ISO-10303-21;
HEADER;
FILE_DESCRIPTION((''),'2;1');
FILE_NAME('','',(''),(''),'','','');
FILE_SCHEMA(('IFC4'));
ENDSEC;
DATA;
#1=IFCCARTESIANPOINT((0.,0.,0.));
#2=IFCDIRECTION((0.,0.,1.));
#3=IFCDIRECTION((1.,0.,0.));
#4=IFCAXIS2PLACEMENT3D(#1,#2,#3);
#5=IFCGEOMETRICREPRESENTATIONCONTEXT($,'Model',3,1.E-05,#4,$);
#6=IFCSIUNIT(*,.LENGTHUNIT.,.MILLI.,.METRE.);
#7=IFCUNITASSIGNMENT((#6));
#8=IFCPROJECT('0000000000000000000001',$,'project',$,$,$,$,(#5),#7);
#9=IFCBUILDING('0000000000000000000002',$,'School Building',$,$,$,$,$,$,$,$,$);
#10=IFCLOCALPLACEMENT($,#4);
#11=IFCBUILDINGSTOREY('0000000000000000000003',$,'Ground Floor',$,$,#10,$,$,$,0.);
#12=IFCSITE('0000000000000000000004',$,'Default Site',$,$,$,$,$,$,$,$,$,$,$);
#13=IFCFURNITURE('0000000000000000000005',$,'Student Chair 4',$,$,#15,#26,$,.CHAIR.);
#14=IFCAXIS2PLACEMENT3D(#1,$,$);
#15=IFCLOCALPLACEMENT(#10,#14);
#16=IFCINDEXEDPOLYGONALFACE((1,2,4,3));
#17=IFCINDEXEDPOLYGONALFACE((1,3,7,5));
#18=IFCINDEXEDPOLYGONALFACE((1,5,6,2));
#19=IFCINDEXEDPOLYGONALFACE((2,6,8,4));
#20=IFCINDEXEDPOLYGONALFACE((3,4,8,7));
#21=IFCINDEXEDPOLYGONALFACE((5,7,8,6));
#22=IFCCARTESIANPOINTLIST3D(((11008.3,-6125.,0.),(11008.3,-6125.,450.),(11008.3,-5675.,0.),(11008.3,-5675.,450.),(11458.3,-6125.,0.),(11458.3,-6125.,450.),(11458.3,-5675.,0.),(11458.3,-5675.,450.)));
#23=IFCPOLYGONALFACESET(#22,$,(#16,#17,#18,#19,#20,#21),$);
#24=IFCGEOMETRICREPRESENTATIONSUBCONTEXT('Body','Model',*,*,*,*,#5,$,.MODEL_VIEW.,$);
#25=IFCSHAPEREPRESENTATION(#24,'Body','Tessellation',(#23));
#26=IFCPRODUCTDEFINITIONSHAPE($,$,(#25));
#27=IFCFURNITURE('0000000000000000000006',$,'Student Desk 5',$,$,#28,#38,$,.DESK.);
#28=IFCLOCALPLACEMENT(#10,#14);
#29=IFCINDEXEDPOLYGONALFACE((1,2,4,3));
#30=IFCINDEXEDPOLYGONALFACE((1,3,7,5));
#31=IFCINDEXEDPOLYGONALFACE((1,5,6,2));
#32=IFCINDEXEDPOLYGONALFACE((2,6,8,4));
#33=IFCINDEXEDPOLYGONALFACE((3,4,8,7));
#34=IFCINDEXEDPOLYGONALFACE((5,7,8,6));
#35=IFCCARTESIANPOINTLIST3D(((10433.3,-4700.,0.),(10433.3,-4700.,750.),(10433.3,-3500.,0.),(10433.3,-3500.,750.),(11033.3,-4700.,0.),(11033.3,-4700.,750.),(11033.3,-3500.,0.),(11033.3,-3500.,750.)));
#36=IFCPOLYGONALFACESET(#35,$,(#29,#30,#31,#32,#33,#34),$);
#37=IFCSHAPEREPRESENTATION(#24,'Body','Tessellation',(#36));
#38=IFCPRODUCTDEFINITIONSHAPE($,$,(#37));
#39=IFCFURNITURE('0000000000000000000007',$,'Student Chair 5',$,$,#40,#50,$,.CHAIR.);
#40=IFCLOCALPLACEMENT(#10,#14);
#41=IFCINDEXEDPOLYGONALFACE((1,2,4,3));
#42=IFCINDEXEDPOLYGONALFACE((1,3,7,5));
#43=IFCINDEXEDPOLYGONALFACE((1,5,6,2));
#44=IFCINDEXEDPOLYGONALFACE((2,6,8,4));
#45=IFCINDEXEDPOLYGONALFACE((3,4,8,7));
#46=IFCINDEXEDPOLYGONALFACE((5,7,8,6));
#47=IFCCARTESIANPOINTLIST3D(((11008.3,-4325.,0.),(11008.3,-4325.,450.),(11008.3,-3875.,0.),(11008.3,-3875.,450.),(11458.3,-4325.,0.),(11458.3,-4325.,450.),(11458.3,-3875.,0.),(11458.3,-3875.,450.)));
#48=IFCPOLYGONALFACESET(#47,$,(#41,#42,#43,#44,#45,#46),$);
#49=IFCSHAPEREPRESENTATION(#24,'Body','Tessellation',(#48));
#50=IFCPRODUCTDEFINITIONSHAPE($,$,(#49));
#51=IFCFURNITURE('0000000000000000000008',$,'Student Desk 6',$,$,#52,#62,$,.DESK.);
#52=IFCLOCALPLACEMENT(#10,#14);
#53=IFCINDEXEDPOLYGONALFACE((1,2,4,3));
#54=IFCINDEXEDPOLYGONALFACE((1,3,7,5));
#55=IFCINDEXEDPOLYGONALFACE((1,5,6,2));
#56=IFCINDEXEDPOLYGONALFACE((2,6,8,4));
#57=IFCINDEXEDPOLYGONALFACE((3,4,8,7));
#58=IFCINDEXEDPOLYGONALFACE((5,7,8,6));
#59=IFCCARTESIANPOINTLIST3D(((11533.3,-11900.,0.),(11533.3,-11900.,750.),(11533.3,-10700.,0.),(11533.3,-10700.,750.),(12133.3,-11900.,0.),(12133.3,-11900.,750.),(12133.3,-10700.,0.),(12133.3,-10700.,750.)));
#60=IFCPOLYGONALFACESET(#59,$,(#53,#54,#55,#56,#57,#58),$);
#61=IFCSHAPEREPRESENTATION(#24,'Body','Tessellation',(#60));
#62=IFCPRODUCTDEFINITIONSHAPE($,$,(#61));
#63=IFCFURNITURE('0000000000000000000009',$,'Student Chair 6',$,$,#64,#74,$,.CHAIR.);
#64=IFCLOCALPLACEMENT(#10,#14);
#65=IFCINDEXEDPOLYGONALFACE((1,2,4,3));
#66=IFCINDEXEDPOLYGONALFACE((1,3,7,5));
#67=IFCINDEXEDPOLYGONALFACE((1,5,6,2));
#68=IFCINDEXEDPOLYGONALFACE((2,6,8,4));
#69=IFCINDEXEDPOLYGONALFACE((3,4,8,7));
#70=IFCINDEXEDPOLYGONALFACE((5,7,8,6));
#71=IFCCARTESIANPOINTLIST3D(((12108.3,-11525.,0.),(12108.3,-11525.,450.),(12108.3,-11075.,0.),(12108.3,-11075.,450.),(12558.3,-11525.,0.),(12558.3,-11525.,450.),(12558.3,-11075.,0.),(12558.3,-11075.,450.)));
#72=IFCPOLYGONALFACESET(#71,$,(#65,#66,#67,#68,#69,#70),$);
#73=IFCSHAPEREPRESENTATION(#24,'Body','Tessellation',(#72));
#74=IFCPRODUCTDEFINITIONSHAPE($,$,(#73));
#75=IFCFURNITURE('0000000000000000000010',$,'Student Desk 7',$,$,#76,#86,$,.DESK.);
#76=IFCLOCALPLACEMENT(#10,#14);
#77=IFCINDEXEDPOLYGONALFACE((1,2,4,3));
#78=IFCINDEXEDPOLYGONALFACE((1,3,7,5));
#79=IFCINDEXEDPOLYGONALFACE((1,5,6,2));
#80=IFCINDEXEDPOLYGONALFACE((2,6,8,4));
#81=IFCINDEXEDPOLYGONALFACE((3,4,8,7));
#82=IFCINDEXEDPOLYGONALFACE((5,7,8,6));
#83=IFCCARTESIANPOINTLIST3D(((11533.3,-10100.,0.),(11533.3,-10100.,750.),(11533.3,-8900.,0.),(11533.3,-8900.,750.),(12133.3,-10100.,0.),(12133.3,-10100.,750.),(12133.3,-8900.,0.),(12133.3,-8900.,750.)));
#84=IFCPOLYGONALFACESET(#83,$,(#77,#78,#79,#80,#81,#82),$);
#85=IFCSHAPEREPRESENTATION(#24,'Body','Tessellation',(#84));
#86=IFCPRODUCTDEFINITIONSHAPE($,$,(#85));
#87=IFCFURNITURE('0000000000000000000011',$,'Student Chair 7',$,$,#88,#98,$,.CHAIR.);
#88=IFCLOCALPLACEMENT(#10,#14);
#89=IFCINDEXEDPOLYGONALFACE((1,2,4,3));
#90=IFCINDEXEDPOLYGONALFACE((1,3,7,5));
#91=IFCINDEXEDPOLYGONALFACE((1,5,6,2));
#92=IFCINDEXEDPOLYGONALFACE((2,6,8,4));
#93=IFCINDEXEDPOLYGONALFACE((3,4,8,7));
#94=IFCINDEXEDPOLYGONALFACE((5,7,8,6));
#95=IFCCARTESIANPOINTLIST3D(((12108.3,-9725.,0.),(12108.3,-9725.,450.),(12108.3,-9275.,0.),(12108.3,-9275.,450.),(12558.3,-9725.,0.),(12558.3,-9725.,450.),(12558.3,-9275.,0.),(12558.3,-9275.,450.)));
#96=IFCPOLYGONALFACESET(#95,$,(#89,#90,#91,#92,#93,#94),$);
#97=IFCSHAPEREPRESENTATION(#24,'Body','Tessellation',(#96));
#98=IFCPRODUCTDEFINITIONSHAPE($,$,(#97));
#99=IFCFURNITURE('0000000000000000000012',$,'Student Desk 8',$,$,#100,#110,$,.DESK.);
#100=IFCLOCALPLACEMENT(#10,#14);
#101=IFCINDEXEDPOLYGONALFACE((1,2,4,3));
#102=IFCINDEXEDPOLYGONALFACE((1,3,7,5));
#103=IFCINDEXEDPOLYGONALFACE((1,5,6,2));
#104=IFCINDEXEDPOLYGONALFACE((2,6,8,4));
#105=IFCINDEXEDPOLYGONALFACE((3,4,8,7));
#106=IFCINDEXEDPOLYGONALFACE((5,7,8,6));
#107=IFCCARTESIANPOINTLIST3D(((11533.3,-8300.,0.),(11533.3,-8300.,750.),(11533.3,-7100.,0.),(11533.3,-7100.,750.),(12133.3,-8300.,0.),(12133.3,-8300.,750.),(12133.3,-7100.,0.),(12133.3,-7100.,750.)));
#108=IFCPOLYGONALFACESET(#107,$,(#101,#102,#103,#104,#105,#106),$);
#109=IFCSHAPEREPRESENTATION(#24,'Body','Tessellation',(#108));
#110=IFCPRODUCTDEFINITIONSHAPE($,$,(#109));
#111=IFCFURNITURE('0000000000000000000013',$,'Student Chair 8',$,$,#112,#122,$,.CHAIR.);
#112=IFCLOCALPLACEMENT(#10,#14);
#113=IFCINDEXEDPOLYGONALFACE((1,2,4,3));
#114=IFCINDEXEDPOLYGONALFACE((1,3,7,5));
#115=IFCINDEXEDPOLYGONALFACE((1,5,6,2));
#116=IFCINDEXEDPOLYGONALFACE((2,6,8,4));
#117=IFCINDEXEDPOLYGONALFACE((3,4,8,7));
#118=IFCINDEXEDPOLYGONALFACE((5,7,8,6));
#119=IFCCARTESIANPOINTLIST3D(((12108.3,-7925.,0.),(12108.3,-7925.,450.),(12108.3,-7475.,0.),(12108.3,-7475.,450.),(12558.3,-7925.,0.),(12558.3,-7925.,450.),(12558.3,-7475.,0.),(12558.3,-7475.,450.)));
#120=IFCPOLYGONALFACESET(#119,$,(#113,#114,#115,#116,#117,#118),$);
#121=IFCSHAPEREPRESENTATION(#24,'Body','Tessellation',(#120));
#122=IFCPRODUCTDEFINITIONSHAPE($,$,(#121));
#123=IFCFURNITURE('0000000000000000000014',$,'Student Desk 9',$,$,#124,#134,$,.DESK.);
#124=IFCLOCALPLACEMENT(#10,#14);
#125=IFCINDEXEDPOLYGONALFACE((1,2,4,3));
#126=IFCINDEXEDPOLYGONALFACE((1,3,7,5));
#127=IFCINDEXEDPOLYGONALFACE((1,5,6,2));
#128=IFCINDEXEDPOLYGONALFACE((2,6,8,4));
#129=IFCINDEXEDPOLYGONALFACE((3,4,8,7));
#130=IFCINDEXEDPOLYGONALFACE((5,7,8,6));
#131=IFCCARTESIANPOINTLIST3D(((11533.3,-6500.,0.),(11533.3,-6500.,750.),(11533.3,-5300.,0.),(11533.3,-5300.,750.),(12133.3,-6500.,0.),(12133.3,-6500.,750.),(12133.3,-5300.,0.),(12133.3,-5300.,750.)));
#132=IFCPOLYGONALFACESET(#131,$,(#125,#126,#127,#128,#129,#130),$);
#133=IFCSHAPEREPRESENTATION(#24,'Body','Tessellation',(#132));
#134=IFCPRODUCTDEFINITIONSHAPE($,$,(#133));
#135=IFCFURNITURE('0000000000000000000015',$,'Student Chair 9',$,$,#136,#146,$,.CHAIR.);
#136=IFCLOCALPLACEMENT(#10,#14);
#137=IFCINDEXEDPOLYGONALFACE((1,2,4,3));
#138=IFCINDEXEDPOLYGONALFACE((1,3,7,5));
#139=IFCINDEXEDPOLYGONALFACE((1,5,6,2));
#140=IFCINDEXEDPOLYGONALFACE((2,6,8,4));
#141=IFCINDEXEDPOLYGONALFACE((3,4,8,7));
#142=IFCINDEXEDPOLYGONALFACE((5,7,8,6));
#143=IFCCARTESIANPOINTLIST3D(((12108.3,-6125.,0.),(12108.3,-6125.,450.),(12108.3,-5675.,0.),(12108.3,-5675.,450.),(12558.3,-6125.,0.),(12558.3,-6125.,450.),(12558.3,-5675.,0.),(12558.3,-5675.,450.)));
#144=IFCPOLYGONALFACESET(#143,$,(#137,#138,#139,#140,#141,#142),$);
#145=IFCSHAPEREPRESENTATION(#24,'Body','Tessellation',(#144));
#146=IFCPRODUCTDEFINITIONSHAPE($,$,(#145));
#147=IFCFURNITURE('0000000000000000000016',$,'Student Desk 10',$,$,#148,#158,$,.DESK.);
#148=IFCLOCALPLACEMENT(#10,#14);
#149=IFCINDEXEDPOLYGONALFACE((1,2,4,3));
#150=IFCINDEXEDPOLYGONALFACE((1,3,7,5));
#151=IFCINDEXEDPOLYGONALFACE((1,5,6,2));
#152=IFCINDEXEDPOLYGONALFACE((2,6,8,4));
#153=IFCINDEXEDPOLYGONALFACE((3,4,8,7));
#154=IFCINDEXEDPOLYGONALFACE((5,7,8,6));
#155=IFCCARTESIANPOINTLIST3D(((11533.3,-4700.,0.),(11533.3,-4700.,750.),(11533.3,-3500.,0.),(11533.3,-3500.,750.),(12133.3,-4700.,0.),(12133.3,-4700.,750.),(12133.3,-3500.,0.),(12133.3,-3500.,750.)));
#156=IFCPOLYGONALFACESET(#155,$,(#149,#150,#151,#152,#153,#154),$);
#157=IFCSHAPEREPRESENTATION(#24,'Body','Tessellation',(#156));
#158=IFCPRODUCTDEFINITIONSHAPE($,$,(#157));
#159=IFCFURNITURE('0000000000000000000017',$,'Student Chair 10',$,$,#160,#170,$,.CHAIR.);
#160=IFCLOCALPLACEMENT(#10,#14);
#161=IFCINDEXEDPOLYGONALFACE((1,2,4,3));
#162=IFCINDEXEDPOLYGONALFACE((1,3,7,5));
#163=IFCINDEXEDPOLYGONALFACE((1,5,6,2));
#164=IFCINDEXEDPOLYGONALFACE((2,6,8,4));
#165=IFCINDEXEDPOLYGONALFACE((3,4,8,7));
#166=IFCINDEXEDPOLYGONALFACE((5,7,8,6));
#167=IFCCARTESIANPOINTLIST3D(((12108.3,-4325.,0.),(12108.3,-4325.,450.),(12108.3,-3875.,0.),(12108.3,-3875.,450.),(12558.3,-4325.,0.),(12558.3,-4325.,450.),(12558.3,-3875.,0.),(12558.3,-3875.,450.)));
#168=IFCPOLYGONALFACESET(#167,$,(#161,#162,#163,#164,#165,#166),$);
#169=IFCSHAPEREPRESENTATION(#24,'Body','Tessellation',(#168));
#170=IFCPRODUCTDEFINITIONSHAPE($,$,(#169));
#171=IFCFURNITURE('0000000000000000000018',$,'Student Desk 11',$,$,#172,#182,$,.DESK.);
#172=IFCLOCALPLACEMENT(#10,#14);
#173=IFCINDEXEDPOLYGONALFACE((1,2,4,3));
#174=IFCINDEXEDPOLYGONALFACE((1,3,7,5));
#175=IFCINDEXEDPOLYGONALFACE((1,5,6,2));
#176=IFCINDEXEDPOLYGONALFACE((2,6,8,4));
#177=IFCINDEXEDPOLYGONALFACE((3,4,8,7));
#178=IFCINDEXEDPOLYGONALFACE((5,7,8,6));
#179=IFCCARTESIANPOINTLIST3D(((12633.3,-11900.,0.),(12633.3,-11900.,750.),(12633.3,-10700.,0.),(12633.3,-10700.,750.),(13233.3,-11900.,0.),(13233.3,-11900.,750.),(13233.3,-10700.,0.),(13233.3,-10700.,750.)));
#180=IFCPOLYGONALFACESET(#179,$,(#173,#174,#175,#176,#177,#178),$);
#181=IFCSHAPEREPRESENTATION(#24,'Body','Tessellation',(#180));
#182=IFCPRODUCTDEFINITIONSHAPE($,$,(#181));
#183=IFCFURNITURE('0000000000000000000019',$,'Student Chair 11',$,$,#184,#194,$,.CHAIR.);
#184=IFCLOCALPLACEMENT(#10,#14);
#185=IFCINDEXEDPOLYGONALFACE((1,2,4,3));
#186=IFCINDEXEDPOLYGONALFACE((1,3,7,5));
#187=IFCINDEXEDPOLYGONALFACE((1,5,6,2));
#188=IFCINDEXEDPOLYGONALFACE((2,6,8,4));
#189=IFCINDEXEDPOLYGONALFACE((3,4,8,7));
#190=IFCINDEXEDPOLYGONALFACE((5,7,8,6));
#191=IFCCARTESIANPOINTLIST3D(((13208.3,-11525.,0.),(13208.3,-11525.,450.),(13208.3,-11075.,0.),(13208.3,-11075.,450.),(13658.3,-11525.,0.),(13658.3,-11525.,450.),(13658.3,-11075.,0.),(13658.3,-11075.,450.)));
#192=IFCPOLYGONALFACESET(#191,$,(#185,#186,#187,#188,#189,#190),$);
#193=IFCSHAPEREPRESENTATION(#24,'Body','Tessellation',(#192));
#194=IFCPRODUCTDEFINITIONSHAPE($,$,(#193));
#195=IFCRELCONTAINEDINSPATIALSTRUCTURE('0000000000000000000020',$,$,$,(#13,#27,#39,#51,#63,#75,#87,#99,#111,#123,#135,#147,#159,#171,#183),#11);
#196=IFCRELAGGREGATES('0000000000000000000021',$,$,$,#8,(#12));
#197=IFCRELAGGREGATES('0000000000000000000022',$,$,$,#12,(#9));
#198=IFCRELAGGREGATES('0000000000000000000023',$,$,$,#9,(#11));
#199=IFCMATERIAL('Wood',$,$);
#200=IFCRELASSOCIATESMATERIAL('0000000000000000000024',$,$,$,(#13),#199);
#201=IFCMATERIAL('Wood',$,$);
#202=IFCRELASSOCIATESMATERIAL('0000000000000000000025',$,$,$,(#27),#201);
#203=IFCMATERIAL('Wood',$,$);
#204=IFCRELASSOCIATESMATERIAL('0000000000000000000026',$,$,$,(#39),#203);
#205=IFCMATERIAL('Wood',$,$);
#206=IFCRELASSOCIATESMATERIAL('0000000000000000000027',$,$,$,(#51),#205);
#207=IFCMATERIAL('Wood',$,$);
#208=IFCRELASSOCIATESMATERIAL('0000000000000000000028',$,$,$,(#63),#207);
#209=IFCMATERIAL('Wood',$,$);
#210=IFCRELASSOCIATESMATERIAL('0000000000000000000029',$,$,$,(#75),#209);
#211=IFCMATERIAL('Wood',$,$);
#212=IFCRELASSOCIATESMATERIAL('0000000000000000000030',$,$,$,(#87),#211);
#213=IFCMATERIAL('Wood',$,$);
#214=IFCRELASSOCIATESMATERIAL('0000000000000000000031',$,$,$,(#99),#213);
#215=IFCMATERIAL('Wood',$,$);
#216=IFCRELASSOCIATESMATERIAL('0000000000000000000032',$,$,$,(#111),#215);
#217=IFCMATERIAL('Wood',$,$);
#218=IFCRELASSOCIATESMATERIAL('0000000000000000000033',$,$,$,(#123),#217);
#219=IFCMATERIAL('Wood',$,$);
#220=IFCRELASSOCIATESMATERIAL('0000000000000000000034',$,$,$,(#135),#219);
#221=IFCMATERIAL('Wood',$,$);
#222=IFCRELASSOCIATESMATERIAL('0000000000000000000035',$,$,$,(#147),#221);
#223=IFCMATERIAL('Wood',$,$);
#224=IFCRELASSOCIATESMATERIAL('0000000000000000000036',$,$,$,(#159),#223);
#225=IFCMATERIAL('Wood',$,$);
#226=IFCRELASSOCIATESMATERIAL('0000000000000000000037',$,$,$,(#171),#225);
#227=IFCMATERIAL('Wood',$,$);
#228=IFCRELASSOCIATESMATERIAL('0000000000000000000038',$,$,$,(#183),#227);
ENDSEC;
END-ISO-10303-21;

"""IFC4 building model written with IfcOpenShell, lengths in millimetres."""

from ifc_helpers import new_model, si_unit, frame, origin_with_axes, origin_2d, place, context, subcontext, project, spatial, rectangle, extrude, material, element, save


model = new_model("IFC4")

# Units and contexts
model_context = context("Model", 3, precision=1e-05, world=origin_with_axes())
body_context = subcontext(model_context, "Body", "Model", "MODEL_VIEW")
ifc_project = project(units=[si_unit("LENGTHUNIT", "METRE", prefix="MILLI")], contexts=[model_context])

# Site, building, storey
site = spatial("IfcSite", under=ifc_project, Name="Default Site")
building = spatial("IfcBuilding", under=site, Name="School Building")
storey_placement = place(None, origin_with_axes())
storey = spatial("IfcBuildingStorey", under=building, at=storey_placement, Name="Ground Floor", Elevation=0.0)

# Furniture
ifc_material_1 = material(Name="Wood")
furniture_1_placement = place(storey_placement, frame((11233.3, -5900.0, 0.0), z_axis=(0.0, 0.0, 1.0), x_axis=(1.0, 0.0, 0.0)))
element("IfcFurniture", 1, at=furniture_1_placement, inside=storey, material=ifc_material_1, Name="Student Chair 4", PredefinedType="CHAIR", context=body_context, shape_type="SweptSolid", body=[
    extrude(rectangle(XDim=450.0, YDim=450.0, at=origin_2d()), origin_with_axes(), (0.0, 0.0, 1.0), 450.0),
])
ifc_material_2 = material(Name="Wood")
furniture_2_placement = place(storey_placement, frame((10733.3, -4100.0, 0.0), z_axis=(0.0, 0.0, 1.0), x_axis=(0.0, 1.0, 0.0)))
element("IfcFurniture", 2, at=furniture_2_placement, inside=storey, material=ifc_material_2, Name="Student Desk 5", PredefinedType="DESK", context=body_context, shape_type="SweptSolid", body=[
    extrude(rectangle(XDim=1200.0, YDim=600.0, at=origin_2d()), origin_with_axes(), (0.0, 0.0, 1.0), 750.0),
])
ifc_material_3 = material(Name="Wood")
furniture_3_placement = place(storey_placement, frame((11233.3, -4100.0, 0.0), z_axis=(0.0, 0.0, 1.0), x_axis=(1.0, 0.0, 0.0)))
element("IfcFurniture", 3, at=furniture_3_placement, inside=storey, material=ifc_material_3, Name="Student Chair 5", PredefinedType="CHAIR", context=body_context, shape_type="SweptSolid", body=[
    extrude(rectangle(XDim=450.0, YDim=450.0, at=origin_2d()), origin_with_axes(), (0.0, 0.0, 1.0), 450.0),
])
ifc_material_4 = material(Name="Wood")
furniture_4_placement = place(storey_placement, frame((11833.3, -11300.0, 0.0), z_axis=(0.0, 0.0, 1.0), x_axis=(0.0, 1.0, 0.0)))
element("IfcFurniture", 4, at=furniture_4_placement, inside=storey, material=ifc_material_4, Name="Student Desk 6", PredefinedType="DESK", context=body_context, shape_type="SweptSolid", body=[
    extrude(rectangle(XDim=1200.0, YDim=600.0, at=origin_2d()), origin_with_axes(), (0.0, 0.0, 1.0), 750.0),
])
ifc_material_5 = material(Name="Wood")
furniture_5_placement = place(storey_placement, frame((12333.3, -11300.0, 0.0), z_axis=(0.0, 0.0, 1.0), x_axis=(1.0, 0.0, 0.0)))
element("IfcFurniture", 5, at=furniture_5_placement, inside=storey, material=ifc_material_5, Name="Student Chair 6", PredefinedType="CHAIR", context=body_context, shape_type="SweptSolid", body=[
    extrude(rectangle(XDim=450.0, YDim=450.0, at=origin_2d()), origin_with_axes(), (0.0, 0.0, 1.0), 450.0),
])
ifc_material_6 = material(Name="Wood")
furniture_6_placement = place(storey_placement, frame((11833.3, -9500.0, 0.0), z_axis=(0.0, 0.0, 1.0), x_axis=(0.0, 1.0, 0.0)))
element("IfcFurniture", 6, at=furniture_6_placement, inside=storey, material=ifc_material_6, Name="Student Desk 7", PredefinedType="DESK", context=body_context, shape_type="SweptSolid", body=[
    extrude(rectangle(XDim=1200.0, YDim=600.0, at=origin_2d()), origin_with_axes(), (0.0, 0.0, 1.0), 750.0),
])
ifc_material_7 = material(Name="Wood")
furniture_7_placement = place(storey_placement, frame((12333.3, -9500.0, 0.0), z_axis=(0.0, 0.0, 1.0), x_axis=(1.0, 0.0, 0.0)))
element("IfcFurniture", 7, at=furniture_7_placement, inside=storey, material=ifc_material_7, Name="Student Chair 7", PredefinedType="CHAIR", context=body_context, shape_type="SweptSolid", body=[
    extrude(rectangle(XDim=450.0, YDim=450.0, at=origin_2d()), origin_with_axes(), (0.0, 0.0, 1.0), 450.0),
])
ifc_material_8 = material(Name="Wood")
furniture_8_placement = place(storey_placement, frame((11833.3, -7700.0, 0.0), z_axis=(0.0, 0.0, 1.0), x_axis=(0.0, 1.0, 0.0)))
element("IfcFurniture", 8, at=furniture_8_placement, inside=storey, material=ifc_material_8, Name="Student Desk 8", PredefinedType="DESK", context=body_context, shape_type="SweptSolid", body=[
    extrude(rectangle(XDim=1200.0, YDim=600.0, at=origin_2d()), origin_with_axes(), (0.0, 0.0, 1.0), 750.0),
])
ifc_material_9 = material(Name="Wood")
furniture_9_placement = place(storey_placement, frame((12333.3, -7700.0, 0.0), z_axis=(0.0, 0.0, 1.0), x_axis=(1.0, 0.0, 0.0)))
element("IfcFurniture", 9, at=furniture_9_placement, inside=storey, material=ifc_material_9, Name="Student Chair 8", PredefinedType="CHAIR", context=body_context, shape_type="SweptSolid", body=[
    extrude(rectangle(XDim=450.0, YDim=450.0, at=origin_2d()), origin_with_axes(), (0.0, 0.0, 1.0), 450.0),
])
ifc_material_10 = material(Name="Wood")
furniture_10_placement = place(storey_placement, frame((11833.3, -5900.0, 0.0), z_axis=(0.0, 0.0, 1.0), x_axis=(0.0, 1.0, 0.0)))
element("IfcFurniture", 10, at=furniture_10_placement, inside=storey, material=ifc_material_10, Name="Student Desk 9", PredefinedType="DESK", context=body_context, shape_type="SweptSolid", body=[
    extrude(rectangle(XDim=1200.0, YDim=600.0, at=origin_2d()), origin_with_axes(), (0.0, 0.0, 1.0), 750.0),
])
ifc_material_11 = material(Name="Wood")
furniture_11_placement = place(storey_placement, frame((12333.3, -5900.0, 0.0), z_axis=(0.0, 0.0, 1.0), x_axis=(1.0, 0.0, 0.0)))
element("IfcFurniture", 11, at=furniture_11_placement, inside=storey, material=ifc_material_11, Name="Student Chair 9", PredefinedType="CHAIR", context=body_context, shape_type="SweptSolid", body=[
    extrude(rectangle(XDim=450.0, YDim=450.0, at=origin_2d()), origin_with_axes(), (0.0, 0.0, 1.0), 450.0),
])
ifc_material_12 = material(Name="Wood")
furniture_12_placement = place(storey_placement, frame((11833.3, -4100.0, 0.0), z_axis=(0.0, 0.0, 1.0), x_axis=(0.0, 1.0, 0.0)))
element("IfcFurniture", 12, at=furniture_12_placement, inside=storey, material=ifc_material_12, Name="Student Desk 10", PredefinedType="DESK", context=body_context, shape_type="SweptSolid", body=[
    extrude(rectangle(XDim=1200.0, YDim=600.0, at=origin_2d()), origin_with_axes(), (0.0, 0.0, 1.0), 750.0),
])
ifc_material_13 = material(Name="Wood")
furniture_13_placement = place(storey_placement, frame((12333.3, -4100.0, 0.0), z_axis=(0.0, 0.0, 1.0), x_axis=(1.0, 0.0, 0.0)))
element("IfcFurniture", 13, at=furniture_13_placement, inside=storey, material=ifc_material_13, Name="Student Chair 10", PredefinedType="CHAIR", context=body_context, shape_type="SweptSolid", body=[
    extrude(rectangle(XDim=450.0, YDim=450.0, at=origin_2d()), origin_with_axes(), (0.0, 0.0, 1.0), 450.0),
])
ifc_material_14 = material(Name="Wood")
furniture_14_placement = place(storey_placement, frame((12933.3, -11300.0, 0.0), z_axis=(0.0, 0.0, 1.0), x_axis=(0.0, 1.0, 0.0)))
element("IfcFurniture", 14, at=furniture_14_placement, inside=storey, material=ifc_material_14, Name="Student Desk 11", PredefinedType="DESK", context=body_context, shape_type="SweptSolid", body=[
    extrude(rectangle(XDim=1200.0, YDim=600.0, at=origin_2d()), origin_with_axes(), (0.0, 0.0, 1.0), 750.0),
])
ifc_material_15 = material(Name="Wood")
furniture_15_placement = place(storey_placement, frame((13433.3, -11300.0, 0.0), z_axis=(0.0, 0.0, 1.0), x_axis=(1.0, 0.0, 0.0)))
element("IfcFurniture", 15, at=furniture_15_placement, inside=storey, material=ifc_material_15, Name="Student Chair 11", PredefinedType="CHAIR", context=body_context, shape_type="SweptSolid", body=[
    extrude(rectangle(XDim=450.0, YDim=450.0, at=origin_2d()), origin_with_axes(), (0.0, 0.0, 1.0), 450.0),
])

save(model, "model.ifc")
